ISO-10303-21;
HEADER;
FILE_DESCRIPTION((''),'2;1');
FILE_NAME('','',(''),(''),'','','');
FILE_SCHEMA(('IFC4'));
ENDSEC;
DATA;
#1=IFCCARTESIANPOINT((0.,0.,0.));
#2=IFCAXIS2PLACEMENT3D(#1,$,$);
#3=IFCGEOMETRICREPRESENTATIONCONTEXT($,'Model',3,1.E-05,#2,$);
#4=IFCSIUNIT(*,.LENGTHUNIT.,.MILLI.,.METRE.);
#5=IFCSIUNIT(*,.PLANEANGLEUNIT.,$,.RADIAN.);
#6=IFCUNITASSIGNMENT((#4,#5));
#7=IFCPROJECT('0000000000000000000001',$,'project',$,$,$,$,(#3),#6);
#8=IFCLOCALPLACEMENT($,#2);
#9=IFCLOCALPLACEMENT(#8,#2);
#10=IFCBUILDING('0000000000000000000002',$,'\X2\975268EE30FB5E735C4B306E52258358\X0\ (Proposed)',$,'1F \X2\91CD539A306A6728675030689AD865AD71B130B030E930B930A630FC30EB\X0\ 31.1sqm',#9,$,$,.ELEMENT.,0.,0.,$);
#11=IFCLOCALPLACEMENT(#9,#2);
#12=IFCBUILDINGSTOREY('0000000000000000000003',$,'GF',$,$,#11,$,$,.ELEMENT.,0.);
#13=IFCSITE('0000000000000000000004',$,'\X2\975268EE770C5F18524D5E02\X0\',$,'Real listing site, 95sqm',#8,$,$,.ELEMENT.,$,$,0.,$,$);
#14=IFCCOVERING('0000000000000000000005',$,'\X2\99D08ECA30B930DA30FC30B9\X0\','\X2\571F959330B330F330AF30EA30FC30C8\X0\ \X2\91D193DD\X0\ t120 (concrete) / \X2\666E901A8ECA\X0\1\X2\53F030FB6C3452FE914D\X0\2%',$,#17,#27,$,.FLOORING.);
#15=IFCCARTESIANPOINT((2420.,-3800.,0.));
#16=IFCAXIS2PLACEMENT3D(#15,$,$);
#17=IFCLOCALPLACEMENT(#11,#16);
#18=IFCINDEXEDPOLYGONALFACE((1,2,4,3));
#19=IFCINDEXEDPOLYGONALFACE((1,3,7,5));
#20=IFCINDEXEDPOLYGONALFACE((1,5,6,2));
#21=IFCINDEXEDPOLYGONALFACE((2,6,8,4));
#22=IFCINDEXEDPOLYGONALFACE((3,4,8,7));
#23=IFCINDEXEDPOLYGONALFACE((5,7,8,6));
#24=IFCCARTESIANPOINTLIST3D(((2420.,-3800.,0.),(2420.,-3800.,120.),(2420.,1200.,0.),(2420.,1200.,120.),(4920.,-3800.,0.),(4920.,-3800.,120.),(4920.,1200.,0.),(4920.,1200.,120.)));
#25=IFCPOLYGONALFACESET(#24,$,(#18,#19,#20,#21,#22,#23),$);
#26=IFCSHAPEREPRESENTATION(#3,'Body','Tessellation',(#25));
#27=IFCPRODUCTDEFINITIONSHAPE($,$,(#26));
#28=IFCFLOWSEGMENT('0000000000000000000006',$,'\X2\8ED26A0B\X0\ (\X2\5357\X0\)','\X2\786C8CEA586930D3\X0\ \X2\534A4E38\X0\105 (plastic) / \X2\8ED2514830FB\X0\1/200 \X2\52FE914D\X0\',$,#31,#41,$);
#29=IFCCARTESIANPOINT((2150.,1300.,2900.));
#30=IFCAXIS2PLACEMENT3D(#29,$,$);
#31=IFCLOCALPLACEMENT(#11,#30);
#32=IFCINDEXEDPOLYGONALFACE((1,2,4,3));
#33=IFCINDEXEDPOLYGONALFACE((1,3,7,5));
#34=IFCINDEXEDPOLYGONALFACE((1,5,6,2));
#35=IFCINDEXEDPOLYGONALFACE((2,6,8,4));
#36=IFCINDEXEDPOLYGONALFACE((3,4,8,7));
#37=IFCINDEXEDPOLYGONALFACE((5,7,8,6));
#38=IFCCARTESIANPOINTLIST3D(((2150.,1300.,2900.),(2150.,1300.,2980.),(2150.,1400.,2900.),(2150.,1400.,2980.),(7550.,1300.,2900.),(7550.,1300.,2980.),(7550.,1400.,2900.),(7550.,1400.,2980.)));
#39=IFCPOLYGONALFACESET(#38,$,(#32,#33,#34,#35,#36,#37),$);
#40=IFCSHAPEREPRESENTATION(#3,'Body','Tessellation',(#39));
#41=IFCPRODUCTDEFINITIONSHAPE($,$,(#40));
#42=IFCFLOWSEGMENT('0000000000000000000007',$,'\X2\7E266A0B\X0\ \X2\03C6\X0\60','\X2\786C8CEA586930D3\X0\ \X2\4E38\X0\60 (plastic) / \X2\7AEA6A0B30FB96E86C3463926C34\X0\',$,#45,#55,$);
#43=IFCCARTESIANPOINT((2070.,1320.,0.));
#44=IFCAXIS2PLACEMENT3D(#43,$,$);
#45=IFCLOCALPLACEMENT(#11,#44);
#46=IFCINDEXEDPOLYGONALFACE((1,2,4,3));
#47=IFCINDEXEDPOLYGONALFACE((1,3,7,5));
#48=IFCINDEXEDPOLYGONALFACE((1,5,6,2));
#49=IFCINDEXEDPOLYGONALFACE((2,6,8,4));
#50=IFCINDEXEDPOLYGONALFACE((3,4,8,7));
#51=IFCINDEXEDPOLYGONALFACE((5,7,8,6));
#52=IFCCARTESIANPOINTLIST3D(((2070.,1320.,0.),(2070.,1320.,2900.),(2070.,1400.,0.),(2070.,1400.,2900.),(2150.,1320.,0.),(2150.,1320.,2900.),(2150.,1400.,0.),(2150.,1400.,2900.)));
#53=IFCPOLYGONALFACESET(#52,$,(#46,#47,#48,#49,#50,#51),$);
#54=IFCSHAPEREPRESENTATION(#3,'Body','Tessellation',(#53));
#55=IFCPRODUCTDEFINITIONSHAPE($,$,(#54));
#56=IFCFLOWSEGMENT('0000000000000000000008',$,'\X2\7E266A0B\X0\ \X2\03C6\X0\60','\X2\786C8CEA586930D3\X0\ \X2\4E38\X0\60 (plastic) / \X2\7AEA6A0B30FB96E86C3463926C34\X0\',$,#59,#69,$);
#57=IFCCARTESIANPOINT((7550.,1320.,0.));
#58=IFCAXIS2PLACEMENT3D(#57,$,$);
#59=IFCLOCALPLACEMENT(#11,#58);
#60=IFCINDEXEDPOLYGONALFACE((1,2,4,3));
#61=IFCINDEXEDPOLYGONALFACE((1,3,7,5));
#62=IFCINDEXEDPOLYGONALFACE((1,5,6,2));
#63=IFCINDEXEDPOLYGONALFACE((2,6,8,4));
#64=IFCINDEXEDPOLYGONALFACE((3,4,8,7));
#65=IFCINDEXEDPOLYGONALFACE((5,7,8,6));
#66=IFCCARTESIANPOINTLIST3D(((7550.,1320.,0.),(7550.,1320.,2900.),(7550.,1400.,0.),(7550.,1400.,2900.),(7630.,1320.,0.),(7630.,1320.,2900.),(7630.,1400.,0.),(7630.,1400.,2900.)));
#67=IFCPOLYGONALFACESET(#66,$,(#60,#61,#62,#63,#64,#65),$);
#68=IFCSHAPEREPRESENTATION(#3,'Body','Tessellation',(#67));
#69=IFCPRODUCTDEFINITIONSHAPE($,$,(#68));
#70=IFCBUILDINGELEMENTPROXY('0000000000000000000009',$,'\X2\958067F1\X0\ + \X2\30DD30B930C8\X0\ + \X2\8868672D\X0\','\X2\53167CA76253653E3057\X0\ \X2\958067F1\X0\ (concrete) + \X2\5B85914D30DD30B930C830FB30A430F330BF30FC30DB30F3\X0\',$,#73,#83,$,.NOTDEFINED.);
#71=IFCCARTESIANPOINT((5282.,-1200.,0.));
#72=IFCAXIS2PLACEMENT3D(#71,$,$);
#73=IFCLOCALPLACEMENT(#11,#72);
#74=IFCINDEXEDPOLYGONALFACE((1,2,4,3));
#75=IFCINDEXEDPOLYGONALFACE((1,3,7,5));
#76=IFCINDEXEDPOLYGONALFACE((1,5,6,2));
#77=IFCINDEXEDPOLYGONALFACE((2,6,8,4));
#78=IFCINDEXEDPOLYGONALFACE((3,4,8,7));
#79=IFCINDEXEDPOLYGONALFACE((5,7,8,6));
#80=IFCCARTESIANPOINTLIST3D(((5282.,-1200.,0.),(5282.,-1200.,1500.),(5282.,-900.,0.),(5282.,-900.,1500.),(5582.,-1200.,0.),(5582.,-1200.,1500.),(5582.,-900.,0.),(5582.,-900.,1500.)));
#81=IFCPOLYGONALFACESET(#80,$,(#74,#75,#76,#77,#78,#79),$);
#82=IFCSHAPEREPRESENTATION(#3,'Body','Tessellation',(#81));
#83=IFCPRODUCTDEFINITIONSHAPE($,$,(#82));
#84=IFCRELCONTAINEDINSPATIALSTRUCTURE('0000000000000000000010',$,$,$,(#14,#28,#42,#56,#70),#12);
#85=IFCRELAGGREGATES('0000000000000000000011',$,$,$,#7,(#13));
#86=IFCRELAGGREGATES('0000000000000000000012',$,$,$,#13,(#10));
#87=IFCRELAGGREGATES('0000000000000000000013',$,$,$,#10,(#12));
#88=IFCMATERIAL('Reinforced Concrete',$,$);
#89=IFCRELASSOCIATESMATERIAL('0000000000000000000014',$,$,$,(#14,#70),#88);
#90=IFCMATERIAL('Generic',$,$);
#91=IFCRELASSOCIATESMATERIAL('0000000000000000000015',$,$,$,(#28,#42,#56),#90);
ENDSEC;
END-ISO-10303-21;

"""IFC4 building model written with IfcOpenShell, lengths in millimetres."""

from ifc_helpers import new_model, si_unit, frame, frame_2d, origin, place, context, project, spatial, rectangle, extrude, material, element, save


model = new_model("IFC4")

# Units and contexts
model_context = context("Model", 3, precision=1e-05, world=origin())
ifc_project = project(units=[si_unit("LENGTHUNIT", "METRE", prefix="MILLI"), si_unit("PLANEANGLEUNIT", "RADIAN")], contexts=[model_context])

# Site, building, storey
site_placement = place(None, origin())
site = spatial("IfcSite", under=ifc_project, at=site_placement, Name="青森県弘前市", ObjectType="Real listing site, 95sqm", CompositionType="ELEMENT", RefElevation=0.0)
building_placement = place(site_placement, origin())
building = spatial("IfcBuilding", under=site, at=building_placement, Name="青森・平屋の別荘 (Proposed)", ObjectType="1F 重厚な木材と高断熱グラスウール 31.1sqm", CompositionType="ELEMENT", ElevationOfRefHeight=0.0, ElevationOfTerrain=0.0)
storey_placement = place(building_placement, origin())
storey = spatial("IfcBuildingStorey", under=building, at=storey_placement, Name="GF", CompositionType="ELEMENT", Elevation=0.0)

# Shared definitions
ifc_material_1 = material(Name="Reinforced Concrete")

# Covering
ifc_material_2 = material(Name="Generic")
covering_1_placement = place(storey_placement, frame((2420.0, -3800.0, 0.0)))
element("IfcCovering", 1, at=covering_1_placement, inside=storey, material=ifc_material_1, Name="駐車スペース", Description="土間コンクリート 金鏝 t120 (concrete) / 普通車1台・水勾配2%", PredefinedType="FLOORING", context=model_context, shape_type="SweptSolid", body=[
    extrude(rectangle(XDim=2500.0, YDim=5000.0, at=frame_2d((1250.0, 2500.0))), frame((2420.0, -3800.0, 0.0)), (0.0, 0.0, 1.0), 120.0),
])

# Flow segments
flow_segment_1_placement = place(storey_placement, frame((2150.0, 1300.0, 2900.0)))
element("IfcFlowSegment", 2, at=flow_segment_1_placement, inside=storey, material=ifc_material_2, Name="軒樋 (南)", Description="硬質塩ビ 半丸105 (plastic) / 軒先・1/200 勾配", context=model_context, shape_type="SweptSolid", body=[
    extrude(rectangle(XDim=5400.0, YDim=100.0, at=frame_2d((2700.0, 50.0))), frame((2150.0, 1300.0, 2900.0)), (0.0, 0.0, 1.0), 80.0),
])
flow_segment_2_placement = place(storey_placement, frame((2070.0, 1320.0, 0.0)))
element("IfcFlowSegment", 3, at=flow_segment_2_placement, inside=storey, material=ifc_material_2, Name="縦樋 φ60", Description="硬質塩ビ 丸60 (plastic) / 竪樋・雨水排水", context=model_context, shape_type="SweptSolid", body=[
    extrude(rectangle(XDim=80.0, YDim=80.0, at=frame_2d((40.0, 40.0))), frame((2070.0, 1320.0, 0.0)), (0.0, 0.0, 1.0), 2900.0),
])
flow_segment_3_placement = place(storey_placement, frame((7550.0, 1320.0, 0.0)))
element("IfcFlowSegment", 4, at=flow_segment_3_placement, inside=storey, material=ifc_material_2, Name="縦樋 φ60", Description="硬質塩ビ 丸60 (plastic) / 竪樋・雨水排水", context=model_context, shape_type="SweptSolid", body=[
    extrude(rectangle(XDim=80.0, YDim=80.0, at=frame_2d((40.0, 40.0))), frame((7550.0, 1320.0, 0.0)), (0.0, 0.0, 1.0), 2900.0),
])

# Building element proxy
proxy_placement = place(storey_placement, frame((5282.0, -1200.0, 0.0)))
element("IfcBuildingElementProxy", 5, at=proxy_placement, inside=storey, material=ifc_material_1, Name="門柱 + ポスト + 表札", Description="化粧打放し 門柱 (concrete) + 宅配ポスト・インターホン", PredefinedType="NOTDEFINED", context=model_context, shape_type="SweptSolid", body=[
    extrude(rectangle(XDim=300.0, YDim=300.0, at=frame_2d((150.0, 150.0))), frame((5282.0, -1200.0, 0.0)), (0.0, 0.0, 1.0), 1500.0),
])

save(model, "model.ifc")
